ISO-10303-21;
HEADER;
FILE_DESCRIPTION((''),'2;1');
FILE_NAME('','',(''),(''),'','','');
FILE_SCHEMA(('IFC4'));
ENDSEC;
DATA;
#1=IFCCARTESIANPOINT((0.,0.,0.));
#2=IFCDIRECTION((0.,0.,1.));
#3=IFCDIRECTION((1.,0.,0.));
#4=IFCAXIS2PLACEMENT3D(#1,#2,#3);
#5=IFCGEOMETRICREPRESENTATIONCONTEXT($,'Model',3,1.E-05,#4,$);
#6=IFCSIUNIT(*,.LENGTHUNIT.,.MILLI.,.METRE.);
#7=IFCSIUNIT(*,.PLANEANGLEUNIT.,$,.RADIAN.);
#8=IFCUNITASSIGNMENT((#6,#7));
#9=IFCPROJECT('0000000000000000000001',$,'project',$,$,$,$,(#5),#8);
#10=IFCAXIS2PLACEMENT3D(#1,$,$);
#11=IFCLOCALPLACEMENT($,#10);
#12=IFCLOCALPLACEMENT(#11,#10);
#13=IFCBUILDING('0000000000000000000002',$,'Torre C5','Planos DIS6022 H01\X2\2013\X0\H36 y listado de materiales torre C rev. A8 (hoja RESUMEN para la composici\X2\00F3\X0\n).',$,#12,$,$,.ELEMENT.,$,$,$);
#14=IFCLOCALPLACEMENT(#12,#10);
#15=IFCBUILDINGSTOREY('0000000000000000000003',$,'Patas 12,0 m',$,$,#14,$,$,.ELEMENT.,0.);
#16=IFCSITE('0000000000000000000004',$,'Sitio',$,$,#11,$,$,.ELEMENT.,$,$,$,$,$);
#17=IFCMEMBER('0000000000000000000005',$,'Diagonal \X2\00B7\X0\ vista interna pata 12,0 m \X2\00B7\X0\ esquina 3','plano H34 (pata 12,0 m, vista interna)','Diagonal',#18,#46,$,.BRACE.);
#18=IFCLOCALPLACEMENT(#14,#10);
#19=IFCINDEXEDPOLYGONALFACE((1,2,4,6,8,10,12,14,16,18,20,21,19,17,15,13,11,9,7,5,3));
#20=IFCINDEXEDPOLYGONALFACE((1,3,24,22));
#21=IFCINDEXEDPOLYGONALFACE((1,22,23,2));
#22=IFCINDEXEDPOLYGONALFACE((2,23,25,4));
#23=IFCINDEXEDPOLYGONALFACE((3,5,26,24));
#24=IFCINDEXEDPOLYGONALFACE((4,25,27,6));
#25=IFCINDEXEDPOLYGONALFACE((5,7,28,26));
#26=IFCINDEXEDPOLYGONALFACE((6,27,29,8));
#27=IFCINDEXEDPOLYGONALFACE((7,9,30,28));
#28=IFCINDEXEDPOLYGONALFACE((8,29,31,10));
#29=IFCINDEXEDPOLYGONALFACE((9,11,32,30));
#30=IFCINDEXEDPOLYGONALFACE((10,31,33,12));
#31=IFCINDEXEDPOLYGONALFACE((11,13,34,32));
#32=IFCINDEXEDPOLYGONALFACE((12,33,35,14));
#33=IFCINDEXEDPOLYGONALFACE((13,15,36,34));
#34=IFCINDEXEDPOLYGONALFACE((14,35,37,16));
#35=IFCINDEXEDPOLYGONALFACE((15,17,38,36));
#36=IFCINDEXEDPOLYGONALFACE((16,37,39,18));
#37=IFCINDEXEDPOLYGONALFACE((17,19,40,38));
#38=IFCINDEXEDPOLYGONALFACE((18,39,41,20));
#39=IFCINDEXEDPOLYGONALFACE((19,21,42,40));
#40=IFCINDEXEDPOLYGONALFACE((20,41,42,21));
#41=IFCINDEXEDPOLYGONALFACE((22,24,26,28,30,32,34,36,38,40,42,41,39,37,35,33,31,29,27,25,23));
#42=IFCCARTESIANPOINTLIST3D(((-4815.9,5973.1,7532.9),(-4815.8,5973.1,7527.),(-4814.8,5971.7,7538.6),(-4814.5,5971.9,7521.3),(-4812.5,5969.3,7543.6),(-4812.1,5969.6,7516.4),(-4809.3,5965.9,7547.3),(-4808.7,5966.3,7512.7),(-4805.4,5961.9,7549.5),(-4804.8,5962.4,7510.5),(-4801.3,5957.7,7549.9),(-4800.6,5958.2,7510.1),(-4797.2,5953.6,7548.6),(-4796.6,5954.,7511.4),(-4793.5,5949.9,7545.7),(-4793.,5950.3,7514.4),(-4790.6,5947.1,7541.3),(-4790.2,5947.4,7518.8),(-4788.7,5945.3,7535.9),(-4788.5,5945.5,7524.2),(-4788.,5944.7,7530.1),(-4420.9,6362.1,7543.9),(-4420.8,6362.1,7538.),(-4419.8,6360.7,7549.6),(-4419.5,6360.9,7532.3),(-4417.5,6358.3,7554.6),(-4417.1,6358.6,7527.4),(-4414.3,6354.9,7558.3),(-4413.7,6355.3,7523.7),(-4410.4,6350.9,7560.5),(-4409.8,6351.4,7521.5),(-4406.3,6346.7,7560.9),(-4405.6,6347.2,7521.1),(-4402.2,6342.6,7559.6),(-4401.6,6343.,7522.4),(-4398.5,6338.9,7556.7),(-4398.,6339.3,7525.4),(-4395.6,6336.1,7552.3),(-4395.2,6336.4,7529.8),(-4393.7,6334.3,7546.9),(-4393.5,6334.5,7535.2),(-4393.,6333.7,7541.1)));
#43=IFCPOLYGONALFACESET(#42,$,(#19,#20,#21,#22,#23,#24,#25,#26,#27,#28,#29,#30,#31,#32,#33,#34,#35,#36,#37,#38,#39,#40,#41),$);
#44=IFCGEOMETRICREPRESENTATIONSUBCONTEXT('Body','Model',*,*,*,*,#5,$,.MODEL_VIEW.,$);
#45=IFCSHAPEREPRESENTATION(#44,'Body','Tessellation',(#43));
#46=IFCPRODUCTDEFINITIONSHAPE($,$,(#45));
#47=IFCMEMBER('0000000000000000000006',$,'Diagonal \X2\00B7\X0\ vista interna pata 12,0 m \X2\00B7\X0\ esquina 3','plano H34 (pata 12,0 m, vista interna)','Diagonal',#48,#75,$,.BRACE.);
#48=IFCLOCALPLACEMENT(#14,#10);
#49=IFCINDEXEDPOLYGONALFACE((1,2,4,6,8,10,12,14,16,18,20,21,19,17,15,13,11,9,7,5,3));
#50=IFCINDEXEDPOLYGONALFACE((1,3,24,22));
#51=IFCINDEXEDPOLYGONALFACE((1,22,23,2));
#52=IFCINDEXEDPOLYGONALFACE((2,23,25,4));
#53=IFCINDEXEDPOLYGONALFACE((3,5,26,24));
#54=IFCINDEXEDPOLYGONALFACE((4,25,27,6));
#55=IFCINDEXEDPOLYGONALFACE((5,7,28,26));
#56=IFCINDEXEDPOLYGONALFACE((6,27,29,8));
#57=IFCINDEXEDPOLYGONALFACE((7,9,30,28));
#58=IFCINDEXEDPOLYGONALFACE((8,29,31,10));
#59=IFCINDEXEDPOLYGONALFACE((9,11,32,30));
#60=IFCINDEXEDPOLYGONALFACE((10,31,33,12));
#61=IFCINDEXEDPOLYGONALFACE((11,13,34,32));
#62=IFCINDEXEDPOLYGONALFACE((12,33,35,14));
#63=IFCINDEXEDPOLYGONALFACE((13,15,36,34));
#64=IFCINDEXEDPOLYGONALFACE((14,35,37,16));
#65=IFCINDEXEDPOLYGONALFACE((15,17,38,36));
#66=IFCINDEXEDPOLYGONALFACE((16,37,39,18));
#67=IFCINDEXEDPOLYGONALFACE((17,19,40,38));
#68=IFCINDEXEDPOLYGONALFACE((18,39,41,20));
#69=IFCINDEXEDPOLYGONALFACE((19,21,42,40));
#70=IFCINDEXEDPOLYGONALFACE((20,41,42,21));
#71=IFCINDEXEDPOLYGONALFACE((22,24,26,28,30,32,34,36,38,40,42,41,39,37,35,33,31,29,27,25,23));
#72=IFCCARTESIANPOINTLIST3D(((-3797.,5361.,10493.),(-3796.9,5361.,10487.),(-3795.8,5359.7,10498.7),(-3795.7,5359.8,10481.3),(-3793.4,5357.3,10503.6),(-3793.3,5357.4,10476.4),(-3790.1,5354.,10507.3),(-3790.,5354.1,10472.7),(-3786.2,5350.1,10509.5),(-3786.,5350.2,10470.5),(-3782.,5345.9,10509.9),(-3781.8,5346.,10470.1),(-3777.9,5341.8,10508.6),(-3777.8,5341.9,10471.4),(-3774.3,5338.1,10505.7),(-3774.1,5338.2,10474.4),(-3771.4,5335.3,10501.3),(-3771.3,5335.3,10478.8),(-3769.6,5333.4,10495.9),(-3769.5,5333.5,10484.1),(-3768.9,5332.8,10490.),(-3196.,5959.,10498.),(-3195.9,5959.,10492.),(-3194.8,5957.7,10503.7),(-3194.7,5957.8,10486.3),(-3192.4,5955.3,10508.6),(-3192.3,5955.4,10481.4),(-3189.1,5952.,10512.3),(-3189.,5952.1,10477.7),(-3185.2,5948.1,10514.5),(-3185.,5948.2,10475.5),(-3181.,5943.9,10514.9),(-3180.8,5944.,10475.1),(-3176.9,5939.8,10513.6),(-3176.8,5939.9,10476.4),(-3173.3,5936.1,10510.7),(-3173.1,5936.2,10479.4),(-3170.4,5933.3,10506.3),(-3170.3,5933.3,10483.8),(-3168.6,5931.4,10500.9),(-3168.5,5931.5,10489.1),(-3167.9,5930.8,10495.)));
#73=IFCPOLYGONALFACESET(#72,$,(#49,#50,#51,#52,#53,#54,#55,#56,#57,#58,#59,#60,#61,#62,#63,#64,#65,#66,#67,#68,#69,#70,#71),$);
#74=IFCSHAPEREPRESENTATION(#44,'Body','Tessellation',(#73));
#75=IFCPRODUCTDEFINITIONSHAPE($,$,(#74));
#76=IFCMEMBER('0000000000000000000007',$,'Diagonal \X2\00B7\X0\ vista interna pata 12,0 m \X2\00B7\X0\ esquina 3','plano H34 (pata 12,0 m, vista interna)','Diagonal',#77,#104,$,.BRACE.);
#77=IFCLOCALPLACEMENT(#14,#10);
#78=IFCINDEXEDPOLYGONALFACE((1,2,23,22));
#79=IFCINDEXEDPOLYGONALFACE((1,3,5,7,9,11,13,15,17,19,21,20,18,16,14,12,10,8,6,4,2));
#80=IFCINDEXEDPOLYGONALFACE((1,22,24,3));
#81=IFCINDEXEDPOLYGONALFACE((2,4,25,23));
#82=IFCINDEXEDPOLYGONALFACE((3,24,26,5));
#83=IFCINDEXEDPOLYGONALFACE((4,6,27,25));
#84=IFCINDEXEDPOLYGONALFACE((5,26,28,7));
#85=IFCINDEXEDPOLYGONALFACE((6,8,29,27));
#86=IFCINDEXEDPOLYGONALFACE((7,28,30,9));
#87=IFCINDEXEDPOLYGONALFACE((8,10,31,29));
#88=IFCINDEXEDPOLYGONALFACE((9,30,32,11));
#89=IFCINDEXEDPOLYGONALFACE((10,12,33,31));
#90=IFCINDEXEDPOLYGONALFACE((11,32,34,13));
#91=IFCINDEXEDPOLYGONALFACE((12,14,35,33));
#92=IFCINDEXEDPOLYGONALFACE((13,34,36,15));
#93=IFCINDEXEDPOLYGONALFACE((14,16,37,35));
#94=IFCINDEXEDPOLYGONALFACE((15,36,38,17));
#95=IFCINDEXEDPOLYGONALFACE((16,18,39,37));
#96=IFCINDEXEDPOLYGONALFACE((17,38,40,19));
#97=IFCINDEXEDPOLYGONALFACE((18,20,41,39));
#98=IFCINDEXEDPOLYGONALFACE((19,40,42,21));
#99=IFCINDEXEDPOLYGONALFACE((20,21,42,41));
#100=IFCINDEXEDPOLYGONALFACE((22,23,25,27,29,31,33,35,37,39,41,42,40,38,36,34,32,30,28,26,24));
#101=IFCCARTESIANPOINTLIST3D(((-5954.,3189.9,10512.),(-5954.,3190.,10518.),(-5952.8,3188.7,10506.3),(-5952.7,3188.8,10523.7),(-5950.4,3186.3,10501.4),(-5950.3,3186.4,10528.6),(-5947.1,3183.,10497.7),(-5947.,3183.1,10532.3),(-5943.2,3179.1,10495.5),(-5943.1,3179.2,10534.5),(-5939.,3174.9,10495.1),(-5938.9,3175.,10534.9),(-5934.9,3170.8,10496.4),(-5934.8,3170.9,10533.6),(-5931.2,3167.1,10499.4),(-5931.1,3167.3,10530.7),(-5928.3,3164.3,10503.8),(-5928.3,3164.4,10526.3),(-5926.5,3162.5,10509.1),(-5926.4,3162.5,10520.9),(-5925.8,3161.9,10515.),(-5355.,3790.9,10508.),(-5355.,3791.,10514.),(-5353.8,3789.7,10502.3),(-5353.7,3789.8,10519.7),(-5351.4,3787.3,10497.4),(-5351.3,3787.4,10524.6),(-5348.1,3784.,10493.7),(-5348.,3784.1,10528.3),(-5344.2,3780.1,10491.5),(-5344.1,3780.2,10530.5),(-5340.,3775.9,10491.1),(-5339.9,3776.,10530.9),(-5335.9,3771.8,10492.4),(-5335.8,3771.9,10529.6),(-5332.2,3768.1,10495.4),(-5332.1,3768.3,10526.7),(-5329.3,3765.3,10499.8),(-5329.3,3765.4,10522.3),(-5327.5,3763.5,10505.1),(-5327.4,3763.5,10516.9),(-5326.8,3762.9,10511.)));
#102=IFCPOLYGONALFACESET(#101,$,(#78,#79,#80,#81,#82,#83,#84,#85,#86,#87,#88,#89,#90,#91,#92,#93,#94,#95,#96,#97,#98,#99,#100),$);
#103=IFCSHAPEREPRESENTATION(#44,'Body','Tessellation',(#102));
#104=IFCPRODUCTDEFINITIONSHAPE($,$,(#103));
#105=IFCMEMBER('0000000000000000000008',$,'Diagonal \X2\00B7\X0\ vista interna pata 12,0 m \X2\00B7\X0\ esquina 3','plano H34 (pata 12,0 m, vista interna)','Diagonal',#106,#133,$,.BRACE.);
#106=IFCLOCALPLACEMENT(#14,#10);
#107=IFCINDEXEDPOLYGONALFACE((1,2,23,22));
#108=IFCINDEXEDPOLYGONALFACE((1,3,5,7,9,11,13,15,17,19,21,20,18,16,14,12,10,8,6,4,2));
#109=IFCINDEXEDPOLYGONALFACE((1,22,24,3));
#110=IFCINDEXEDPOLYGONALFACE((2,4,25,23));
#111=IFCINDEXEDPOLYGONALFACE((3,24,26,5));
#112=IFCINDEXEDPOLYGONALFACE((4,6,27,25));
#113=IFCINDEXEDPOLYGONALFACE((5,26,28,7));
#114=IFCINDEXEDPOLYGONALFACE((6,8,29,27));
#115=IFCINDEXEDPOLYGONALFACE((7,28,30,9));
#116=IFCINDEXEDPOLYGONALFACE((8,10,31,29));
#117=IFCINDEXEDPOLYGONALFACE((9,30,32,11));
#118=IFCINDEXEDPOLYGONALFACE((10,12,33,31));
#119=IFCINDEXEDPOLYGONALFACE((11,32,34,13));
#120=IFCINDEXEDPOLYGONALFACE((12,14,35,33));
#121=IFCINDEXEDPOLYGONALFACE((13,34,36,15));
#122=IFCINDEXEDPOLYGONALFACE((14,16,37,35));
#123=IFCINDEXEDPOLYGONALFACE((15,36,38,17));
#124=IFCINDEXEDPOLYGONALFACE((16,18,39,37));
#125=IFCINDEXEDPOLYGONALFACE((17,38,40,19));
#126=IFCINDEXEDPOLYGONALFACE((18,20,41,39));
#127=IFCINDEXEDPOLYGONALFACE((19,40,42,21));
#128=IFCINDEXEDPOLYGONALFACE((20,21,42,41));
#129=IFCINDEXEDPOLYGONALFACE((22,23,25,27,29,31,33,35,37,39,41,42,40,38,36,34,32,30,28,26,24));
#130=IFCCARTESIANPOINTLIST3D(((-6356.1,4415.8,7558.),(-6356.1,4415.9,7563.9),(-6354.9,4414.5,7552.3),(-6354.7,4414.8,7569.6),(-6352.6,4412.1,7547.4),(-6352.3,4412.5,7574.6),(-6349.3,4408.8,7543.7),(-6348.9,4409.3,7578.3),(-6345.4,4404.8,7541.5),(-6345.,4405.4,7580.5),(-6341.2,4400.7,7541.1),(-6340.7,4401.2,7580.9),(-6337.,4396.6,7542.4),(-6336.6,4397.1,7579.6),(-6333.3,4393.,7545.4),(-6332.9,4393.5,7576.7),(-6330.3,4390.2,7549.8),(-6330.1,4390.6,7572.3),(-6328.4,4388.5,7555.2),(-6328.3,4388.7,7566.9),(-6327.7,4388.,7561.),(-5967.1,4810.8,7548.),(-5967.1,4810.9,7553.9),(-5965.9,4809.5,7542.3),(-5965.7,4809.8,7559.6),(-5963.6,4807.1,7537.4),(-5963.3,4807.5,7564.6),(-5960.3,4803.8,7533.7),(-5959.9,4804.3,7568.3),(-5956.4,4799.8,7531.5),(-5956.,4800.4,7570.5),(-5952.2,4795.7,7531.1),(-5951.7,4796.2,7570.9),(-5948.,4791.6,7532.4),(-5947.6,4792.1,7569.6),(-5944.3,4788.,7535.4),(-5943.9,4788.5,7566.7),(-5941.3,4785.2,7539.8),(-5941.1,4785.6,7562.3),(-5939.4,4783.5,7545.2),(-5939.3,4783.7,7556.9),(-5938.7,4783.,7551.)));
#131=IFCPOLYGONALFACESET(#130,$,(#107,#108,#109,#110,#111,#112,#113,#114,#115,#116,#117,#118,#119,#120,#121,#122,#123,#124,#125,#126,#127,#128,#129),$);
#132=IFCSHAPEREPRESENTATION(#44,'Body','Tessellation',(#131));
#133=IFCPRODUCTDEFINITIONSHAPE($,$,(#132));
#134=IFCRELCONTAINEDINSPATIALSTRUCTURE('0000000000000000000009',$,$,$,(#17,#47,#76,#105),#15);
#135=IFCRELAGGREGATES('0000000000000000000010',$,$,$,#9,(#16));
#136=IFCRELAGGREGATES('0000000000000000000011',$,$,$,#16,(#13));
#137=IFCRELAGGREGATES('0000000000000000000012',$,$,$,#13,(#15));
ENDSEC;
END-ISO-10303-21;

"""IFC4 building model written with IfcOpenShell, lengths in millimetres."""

from ifc_helpers import new_model, si_unit, frame, origin, origin_with_axes, place, context, subcontext, project, spatial, circle, extrude, element, save


model = new_model("IFC4")

# Units and contexts
model_context = context("Model", 3, precision=1e-05, world=origin_with_axes())
body_context = subcontext(model_context, "Body", "Model", "MODEL_VIEW")
ifc_project = project(units=[si_unit("LENGTHUNIT", "METRE", prefix="MILLI"), si_unit("PLANEANGLEUNIT", "RADIAN")], contexts=[model_context])

# Site, building, storey
site_placement = place(None, origin())
site = spatial("IfcSite", under=ifc_project, at=site_placement, Name="Sitio", CompositionType="ELEMENT")
building_placement = place(site_placement, origin())
building = spatial("IfcBuilding", under=site, at=building_placement, Name="Torre C5", Description="Planos DIS6022 H01–H36 y listado de materiales torre C rev. A8 (hoja RESUMEN para la composición).", CompositionType="ELEMENT")
storey_placement = place(building_placement, origin())
storey = spatial("IfcBuildingStorey", under=building, at=storey_placement, Name="Patas 12,0 m", CompositionType="ELEMENT", Elevation=0.0)

# Members
member_1_placement = place(storey_placement, frame((-4407.0, 6348.0, 7541.0), z_axis=(-0.712357, -0.701537, -0.019838), x_axis=(0.701634, -0.712532, 0.002701)))
element("IfcMember", 1, at=member_1_placement, inside=storey, Name="Diagonal · vista interna pata 12,0 m · esquina 3", Description="plano H34 (pata 12,0 m, vista interna)", ObjectType="Diagonal", PredefinedType="BRACE", context=body_context, shape_type="SweptSolid", body=[
    extrude(circle(Radius=20.0), None, (0.0, 0.0, 1.0), 554.5),
])
member_2_placement = place(storey_placement, frame((-3182.0, 5945.0, 10495.0), z_axis=(-0.708861, -0.705323, -0.005897), x_axis=(0.705329, -0.708879, 0.001382)))
element("IfcMember", 2, at=member_2_placement, inside=storey, Name="Diagonal · vista interna pata 12,0 m · esquina 3", Description="plano H34 (pata 12,0 m, vista interna)", ObjectType="Diagonal", PredefinedType="BRACE", context=body_context, shape_type="SweptSolid", body=[
    extrude(circle(Radius=20.0), None, (0.0, 0.0, 1.0), 847.8),
])
member_3_placement = place(storey_placement, frame((-5341.0, 3777.0, 10511.0), z_axis=(-0.705919, -0.708276, 0.004714), x_axis=(0.708288, -0.705923, 0.001111)))
element("IfcMember", 3, at=member_3_placement, inside=storey, Name="Diagonal · vista interna pata 12,0 m · esquina 3", Description="plano H34 (pata 12,0 m, vista interna)", ObjectType="Diagonal", PredefinedType="BRACE", context=body_context, shape_type="SweptSolid", body=[
    extrude(circle(Radius=20.0), None, (0.0, 0.0, 1.0), 848.5),
])
member_4_placement = place(storey_placement, frame((-5953.0, 4797.0, 7551.0), z_axis=(-0.701561, -0.712382, 0.018035), x_axis=(0.712526, -0.701641, 0.002457)))
element("IfcMember", 4, at=member_4_placement, inside=storey, Name="Diagonal · vista interna pata 12,0 m · esquina 3", Description="plano H34 (pata 12,0 m, vista interna)", ObjectType="Diagonal", PredefinedType="BRACE", context=body_context, shape_type="SweptSolid", body=[
    extrude(circle(Radius=20.0), None, (0.0, 0.0, 1.0), 554.5),
])

save(model, "model.ifc")
